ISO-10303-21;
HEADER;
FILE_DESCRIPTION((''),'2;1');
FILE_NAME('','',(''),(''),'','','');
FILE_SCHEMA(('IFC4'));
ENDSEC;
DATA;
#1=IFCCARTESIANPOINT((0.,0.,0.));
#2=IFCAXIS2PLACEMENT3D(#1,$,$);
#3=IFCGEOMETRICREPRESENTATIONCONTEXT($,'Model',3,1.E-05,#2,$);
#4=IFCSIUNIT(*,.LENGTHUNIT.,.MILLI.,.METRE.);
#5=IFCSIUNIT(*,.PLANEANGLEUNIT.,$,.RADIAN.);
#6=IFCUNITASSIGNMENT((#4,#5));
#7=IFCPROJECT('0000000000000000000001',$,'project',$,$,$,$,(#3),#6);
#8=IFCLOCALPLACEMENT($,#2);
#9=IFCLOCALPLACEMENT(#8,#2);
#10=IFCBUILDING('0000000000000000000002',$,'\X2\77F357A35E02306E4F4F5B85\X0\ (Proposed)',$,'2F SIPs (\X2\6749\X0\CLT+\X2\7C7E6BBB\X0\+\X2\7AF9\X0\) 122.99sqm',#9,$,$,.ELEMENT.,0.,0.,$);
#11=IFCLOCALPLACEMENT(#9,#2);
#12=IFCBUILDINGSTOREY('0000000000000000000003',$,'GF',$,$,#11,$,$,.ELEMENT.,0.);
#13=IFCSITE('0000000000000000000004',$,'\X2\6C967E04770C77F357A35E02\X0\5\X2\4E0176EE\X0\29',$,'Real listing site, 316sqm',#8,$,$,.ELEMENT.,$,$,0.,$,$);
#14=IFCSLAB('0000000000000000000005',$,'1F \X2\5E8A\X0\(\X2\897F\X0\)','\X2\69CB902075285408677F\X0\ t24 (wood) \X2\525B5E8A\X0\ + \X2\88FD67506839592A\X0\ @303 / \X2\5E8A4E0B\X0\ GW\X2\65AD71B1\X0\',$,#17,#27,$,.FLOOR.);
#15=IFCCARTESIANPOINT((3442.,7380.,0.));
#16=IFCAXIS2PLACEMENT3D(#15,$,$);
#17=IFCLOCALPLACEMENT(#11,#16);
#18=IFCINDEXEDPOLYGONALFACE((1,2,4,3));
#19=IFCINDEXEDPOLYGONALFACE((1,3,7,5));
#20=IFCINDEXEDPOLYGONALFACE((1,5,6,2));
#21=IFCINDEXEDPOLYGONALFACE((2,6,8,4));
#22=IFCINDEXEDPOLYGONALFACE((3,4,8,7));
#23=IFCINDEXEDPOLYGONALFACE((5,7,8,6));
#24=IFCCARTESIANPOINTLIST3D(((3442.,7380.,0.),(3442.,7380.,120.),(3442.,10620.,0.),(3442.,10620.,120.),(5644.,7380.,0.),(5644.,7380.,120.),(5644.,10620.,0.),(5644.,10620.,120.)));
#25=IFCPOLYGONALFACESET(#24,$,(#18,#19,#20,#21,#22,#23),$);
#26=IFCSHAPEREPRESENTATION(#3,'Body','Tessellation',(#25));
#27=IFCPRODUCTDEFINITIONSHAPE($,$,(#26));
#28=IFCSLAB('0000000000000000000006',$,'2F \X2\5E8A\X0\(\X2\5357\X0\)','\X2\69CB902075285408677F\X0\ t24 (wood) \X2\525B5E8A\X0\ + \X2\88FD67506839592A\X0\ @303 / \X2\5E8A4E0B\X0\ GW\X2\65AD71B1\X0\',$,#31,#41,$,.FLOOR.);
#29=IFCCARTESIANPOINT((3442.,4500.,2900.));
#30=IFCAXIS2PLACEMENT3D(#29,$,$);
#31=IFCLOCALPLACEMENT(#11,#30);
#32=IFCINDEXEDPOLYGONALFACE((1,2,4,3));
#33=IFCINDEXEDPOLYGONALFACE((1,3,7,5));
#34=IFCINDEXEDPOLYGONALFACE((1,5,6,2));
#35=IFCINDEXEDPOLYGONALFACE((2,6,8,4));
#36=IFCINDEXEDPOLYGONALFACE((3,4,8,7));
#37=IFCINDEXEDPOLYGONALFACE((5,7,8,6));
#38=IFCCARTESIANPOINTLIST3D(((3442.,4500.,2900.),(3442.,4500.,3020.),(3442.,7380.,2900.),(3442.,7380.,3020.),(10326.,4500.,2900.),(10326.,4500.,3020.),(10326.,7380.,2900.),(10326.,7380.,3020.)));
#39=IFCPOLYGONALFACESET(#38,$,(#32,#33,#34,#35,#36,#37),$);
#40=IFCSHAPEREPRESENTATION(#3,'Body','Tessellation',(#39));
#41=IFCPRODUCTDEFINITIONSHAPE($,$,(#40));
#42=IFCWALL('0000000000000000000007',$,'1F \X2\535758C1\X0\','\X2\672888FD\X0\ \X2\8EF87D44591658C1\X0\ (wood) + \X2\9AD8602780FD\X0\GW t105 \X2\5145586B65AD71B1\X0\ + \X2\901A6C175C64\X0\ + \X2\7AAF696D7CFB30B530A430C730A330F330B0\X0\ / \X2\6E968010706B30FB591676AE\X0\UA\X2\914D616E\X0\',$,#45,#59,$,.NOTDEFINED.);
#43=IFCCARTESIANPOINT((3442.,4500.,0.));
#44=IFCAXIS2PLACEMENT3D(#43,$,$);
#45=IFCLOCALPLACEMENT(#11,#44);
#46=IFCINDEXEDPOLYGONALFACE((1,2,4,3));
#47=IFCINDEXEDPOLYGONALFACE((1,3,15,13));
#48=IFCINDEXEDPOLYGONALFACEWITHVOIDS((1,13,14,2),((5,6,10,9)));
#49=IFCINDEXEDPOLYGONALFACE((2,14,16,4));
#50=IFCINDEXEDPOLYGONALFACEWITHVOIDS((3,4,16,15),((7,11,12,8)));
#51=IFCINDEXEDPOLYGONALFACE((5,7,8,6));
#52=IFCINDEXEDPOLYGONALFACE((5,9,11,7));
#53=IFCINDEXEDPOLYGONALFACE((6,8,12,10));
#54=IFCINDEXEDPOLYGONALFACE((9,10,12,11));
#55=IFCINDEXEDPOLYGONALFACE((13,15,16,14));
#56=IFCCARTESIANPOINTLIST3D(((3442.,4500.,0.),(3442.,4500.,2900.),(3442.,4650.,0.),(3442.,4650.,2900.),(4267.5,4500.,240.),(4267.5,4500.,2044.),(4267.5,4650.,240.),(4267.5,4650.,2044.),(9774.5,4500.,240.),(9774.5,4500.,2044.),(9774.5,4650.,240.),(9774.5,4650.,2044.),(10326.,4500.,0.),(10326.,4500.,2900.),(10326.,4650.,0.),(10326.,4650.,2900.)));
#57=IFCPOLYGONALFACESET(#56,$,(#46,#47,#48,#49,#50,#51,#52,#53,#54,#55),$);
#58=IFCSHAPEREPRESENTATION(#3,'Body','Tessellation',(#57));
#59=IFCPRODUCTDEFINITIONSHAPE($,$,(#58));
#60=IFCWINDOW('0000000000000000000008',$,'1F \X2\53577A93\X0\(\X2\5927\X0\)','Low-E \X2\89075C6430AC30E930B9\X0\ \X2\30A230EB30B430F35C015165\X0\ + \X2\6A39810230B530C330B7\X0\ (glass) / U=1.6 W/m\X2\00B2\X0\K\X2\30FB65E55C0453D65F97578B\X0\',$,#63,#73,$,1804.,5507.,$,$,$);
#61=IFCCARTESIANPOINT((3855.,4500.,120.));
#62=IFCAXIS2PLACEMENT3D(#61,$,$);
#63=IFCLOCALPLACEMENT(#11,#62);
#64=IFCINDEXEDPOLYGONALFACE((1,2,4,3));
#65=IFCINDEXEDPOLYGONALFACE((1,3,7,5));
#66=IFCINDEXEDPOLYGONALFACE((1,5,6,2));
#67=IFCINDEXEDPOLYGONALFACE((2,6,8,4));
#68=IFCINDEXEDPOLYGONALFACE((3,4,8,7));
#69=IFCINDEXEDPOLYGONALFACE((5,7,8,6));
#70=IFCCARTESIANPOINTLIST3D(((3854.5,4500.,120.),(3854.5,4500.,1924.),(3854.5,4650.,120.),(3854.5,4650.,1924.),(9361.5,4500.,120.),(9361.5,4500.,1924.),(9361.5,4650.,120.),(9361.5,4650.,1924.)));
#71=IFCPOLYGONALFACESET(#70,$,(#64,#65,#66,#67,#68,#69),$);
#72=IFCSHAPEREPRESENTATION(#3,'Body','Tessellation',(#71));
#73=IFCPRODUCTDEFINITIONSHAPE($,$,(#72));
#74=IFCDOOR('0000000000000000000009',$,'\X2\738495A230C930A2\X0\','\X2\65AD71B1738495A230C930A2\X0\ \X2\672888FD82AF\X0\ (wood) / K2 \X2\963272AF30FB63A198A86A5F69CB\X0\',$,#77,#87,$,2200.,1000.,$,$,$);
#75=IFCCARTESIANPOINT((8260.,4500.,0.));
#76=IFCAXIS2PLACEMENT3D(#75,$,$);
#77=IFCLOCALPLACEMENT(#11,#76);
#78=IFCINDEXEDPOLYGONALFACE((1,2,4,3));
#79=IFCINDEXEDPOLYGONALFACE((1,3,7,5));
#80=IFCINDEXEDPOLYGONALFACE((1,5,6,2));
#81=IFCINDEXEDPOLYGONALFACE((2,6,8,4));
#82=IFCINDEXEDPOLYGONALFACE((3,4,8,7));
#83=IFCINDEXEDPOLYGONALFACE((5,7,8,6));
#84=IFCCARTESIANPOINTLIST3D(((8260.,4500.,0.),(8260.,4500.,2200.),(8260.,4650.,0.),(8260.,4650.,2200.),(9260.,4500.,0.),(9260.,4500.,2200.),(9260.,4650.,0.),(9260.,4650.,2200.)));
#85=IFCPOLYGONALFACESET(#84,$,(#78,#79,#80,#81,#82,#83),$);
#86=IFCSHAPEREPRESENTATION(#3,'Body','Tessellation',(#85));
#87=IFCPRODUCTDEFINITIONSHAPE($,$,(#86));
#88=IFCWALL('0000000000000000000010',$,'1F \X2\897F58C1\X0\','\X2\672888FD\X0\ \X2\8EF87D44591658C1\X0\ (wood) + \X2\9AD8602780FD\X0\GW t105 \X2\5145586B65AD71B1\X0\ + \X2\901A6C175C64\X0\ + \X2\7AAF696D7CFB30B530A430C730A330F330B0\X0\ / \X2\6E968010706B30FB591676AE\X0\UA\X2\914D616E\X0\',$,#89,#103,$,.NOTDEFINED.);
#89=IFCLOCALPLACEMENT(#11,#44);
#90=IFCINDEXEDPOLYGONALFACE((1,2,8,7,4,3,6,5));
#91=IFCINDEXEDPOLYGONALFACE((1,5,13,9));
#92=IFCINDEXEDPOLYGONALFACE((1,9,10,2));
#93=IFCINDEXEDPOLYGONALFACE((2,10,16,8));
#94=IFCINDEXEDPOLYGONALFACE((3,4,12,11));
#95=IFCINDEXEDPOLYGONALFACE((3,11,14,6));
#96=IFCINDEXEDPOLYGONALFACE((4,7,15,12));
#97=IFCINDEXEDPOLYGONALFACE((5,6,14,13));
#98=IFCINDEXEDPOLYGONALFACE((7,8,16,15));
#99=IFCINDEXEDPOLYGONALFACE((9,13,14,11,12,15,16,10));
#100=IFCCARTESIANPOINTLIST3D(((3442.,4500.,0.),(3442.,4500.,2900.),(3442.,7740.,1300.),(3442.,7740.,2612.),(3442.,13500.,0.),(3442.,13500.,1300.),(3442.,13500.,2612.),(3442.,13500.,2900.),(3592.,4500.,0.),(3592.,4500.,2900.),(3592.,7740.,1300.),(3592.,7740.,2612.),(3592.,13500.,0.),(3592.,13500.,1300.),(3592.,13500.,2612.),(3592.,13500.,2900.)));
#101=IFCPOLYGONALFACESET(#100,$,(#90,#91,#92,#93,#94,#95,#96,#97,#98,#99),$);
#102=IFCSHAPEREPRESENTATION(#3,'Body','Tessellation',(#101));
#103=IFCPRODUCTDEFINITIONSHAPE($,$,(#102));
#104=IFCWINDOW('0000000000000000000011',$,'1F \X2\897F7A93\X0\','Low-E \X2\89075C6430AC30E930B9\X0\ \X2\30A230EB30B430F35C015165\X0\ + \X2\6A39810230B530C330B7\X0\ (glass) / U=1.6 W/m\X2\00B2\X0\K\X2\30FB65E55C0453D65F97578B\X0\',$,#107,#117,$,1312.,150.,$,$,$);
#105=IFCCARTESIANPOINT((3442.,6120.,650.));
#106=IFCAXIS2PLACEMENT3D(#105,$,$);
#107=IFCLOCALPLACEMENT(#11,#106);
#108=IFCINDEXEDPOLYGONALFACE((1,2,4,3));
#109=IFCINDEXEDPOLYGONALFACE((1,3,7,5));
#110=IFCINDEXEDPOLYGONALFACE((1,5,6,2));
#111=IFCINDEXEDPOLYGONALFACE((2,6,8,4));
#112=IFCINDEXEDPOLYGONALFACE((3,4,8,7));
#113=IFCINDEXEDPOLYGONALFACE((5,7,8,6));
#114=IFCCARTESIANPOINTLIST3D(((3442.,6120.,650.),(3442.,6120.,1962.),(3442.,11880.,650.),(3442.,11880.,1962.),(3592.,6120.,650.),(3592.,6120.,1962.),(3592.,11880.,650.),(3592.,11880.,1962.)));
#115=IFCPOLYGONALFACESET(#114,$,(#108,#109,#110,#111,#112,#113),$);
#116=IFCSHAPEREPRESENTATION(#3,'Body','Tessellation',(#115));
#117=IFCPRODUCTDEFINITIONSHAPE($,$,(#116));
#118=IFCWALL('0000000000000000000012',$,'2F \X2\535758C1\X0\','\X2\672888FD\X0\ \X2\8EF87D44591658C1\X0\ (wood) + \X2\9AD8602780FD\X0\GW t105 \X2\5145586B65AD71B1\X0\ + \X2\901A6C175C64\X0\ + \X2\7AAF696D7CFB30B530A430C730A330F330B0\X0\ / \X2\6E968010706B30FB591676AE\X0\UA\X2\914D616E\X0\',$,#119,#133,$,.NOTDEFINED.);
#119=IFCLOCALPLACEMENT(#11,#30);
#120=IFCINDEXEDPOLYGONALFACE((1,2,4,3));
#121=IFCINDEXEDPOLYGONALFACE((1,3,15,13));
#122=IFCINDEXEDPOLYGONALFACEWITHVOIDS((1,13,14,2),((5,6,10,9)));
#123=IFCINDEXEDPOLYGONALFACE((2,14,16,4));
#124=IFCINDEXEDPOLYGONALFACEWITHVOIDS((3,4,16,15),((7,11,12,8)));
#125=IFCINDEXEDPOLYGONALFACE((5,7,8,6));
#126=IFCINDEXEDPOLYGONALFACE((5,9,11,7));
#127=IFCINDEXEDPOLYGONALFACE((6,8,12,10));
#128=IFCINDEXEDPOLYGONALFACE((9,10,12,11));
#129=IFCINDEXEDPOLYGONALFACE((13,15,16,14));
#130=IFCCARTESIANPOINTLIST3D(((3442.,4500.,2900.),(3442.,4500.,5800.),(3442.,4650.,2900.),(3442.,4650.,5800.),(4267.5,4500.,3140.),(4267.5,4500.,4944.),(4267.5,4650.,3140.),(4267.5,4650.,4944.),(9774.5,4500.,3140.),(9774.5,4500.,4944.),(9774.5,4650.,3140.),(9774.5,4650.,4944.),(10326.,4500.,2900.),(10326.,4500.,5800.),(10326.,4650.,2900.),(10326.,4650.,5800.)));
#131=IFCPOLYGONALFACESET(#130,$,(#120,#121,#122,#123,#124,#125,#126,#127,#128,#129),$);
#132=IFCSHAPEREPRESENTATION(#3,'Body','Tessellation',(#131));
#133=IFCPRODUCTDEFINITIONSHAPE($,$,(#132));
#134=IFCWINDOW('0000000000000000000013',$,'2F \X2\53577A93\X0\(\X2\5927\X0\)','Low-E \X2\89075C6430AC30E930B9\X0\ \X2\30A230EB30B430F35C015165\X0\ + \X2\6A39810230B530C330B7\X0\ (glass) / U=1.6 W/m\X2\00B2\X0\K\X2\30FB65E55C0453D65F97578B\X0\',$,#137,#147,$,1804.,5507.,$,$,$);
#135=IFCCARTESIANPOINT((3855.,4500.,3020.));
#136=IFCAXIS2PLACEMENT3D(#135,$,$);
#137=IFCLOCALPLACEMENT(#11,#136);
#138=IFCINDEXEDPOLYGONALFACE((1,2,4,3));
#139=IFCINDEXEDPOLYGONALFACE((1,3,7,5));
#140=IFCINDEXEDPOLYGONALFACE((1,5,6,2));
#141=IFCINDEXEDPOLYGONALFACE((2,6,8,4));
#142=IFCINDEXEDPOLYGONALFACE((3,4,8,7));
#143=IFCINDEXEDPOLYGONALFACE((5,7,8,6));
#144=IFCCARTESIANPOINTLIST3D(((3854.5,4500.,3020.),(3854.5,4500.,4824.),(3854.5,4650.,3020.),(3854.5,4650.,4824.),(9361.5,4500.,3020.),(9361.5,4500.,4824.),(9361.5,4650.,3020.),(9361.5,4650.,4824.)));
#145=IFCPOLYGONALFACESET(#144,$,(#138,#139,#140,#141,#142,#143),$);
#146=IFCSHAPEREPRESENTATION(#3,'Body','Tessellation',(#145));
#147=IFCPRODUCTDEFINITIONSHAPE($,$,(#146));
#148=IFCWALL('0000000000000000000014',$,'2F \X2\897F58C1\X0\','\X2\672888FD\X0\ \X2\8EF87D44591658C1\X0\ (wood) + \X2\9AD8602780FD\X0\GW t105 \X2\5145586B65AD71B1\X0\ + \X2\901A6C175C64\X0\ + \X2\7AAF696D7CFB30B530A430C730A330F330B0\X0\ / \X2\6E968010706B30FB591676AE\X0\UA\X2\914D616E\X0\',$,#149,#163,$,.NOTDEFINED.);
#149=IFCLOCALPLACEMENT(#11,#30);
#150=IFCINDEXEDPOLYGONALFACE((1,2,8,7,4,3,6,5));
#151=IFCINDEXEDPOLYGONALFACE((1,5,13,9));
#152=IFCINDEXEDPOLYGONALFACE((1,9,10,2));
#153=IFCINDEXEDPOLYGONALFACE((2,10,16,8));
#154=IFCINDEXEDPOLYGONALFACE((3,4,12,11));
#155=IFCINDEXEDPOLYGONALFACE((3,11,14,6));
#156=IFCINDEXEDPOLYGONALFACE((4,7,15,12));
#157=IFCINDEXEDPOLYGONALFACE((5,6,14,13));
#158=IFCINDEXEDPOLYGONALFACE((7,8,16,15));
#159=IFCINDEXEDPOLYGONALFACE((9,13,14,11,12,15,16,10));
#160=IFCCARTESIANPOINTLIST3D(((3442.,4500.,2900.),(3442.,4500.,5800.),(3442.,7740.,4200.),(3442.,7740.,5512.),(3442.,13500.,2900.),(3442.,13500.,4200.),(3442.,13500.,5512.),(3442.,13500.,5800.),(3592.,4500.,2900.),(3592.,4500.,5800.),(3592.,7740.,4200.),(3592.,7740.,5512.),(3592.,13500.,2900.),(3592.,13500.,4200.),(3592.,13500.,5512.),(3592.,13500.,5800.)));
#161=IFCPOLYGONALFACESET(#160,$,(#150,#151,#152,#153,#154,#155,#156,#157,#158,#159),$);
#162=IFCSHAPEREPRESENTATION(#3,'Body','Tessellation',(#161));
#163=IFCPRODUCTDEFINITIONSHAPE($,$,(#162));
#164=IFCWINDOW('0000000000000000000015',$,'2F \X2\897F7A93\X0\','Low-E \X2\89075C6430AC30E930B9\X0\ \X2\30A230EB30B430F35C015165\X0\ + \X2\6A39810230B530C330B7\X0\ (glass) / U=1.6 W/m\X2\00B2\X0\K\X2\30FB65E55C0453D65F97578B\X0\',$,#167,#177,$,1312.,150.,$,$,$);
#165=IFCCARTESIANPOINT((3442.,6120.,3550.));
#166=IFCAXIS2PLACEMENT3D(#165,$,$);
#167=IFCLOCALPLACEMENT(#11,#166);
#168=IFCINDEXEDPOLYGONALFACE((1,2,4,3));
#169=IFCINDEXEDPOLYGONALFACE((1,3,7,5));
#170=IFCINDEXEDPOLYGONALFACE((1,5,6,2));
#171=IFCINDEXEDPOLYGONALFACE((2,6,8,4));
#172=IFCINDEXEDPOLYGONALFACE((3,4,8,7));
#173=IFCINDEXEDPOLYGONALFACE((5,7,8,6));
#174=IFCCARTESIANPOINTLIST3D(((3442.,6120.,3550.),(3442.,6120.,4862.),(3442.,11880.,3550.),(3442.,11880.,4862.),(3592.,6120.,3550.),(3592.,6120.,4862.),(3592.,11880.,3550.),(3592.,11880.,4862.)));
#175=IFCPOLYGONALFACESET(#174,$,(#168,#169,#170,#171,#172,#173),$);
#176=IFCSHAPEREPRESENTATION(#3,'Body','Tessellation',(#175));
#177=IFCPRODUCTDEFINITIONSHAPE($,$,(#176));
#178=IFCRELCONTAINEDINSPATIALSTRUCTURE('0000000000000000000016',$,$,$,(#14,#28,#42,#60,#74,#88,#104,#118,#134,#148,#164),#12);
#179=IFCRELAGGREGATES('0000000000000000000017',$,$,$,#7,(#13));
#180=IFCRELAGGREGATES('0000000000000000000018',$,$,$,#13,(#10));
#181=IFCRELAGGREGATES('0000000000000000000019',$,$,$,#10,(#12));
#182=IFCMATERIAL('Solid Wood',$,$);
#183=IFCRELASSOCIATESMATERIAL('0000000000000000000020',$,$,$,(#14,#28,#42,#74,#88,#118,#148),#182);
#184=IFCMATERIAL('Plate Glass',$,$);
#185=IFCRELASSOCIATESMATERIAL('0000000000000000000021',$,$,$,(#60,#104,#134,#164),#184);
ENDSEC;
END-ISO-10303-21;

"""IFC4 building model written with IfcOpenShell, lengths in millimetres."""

from ifc_helpers import new_model, si_unit, frame, frame_2d, origin, place, context, project, spatial, rectangle, extrude, material, element, fill, save


model = new_model("IFC4")

# Units and contexts
model_context = context("Model", 3, precision=1e-05, world=origin())
ifc_project = project(units=[si_unit("LENGTHUNIT", "METRE", prefix="MILLI"), si_unit("PLANEANGLEUNIT", "RADIAN")], contexts=[model_context])

# Site, building, storey
site_placement = place(None, origin())
site = spatial("IfcSite", under=ifc_project, at=site_placement, Name="沖縄県石垣市5丁目29", ObjectType="Real listing site, 316sqm", CompositionType="ELEMENT", RefElevation=0.0)
building_placement = place(site_placement, origin())
building = spatial("IfcBuilding", under=site, at=building_placement, Name="石垣市の住宅 (Proposed)", ObjectType="2F SIPs (杉CLT+籾殻+竹) 122.99sqm", CompositionType="ELEMENT", ElevationOfRefHeight=0.0, ElevationOfTerrain=0.0)
storey_placement = place(building_placement, origin())
storey = spatial("IfcBuildingStorey", under=building, at=storey_placement, Name="GF", CompositionType="ELEMENT", Elevation=0.0)

# Slabs
ifc_material_1 = material(Name="Solid Wood")
slab_1_placement = place(storey_placement, frame((3442.0, 7380.0, 0.0)))
element("IfcSlab", 1, at=slab_1_placement, inside=storey, material=ifc_material_1, Name="1F 床(西)", Description="構造用合板 t24 (wood) 剛床 + 製材根太 @303 / 床下 GW断熱", PredefinedType="FLOOR", context=model_context, shape_type="SweptSolid", body=[
    extrude(rectangle(XDim=2202.0, YDim=3240.0, at=frame_2d((1101.0, 1620.0))), frame((3442.0, 7380.0, 0.0)), (0.0, 0.0, 1.0), 120.0),
])
slab_2_placement = place(storey_placement, frame((3442.0, 4500.0, 2900.0)))
element("IfcSlab", 2, at=slab_2_placement, inside=storey, material=ifc_material_1, Name="2F 床(南)", Description="構造用合板 t24 (wood) 剛床 + 製材根太 @303 / 床下 GW断熱", PredefinedType="FLOOR", context=model_context, shape_type="SweptSolid", body=[
    extrude(rectangle(XDim=6884.0, YDim=2880.0, at=frame_2d((3442.0, 1440.0))), frame((3442.0, 4500.0, 2900.0)), (0.0, 0.0, 1.0), 120.0),
])

# Wall, openings, window, door
wall_1_placement = place(storey_placement, frame((3442.0, 4500.0, 0.0)))
wall_1 = element("IfcWall", 3, at=wall_1_placement, inside=storey, material=ifc_material_1, Name="1F 南壁", Description="木製 軸組外壁 (wood) + 高性能GW t105 充填断熱 + 通気層 + 窯業系サイディング / 準耐火・外皮UA配慮", PredefinedType="NOTDEFINED", context=model_context, shape_type="SweptSolid", body=[
    extrude(rectangle(XDim=6884.0, YDim=150.0, at=frame_2d((3442.0, 75.0))), frame((3442.0, 4500.0, 0.0)), (0.0, 0.0, 1.0), 2900.0),
])
opening_1_placement = place(storey_placement, frame((3855.0, 4500.0, 120.0)))
opening_1 = element("IfcOpeningElement", 4, at=opening_1_placement, cuts=wall_1, PredefinedType="NOTDEFINED", context=model_context, shape_type="SweptSolid", body=[
    extrude(rectangle(XDim=5507.0, YDim=150.0, at=frame_2d((2753.0, 75.0))), frame((3855.0, 4500.0, 120.0)), (0.0, 0.0, 1.0), 1804.0),
])
opening_2_placement = place(storey_placement, frame((8260.0, 4500.0, 0.0)))
opening_2 = element("IfcOpeningElement", 5, at=opening_2_placement, cuts=wall_1, PredefinedType="NOTDEFINED", context=model_context, shape_type="SweptSolid", body=[
    extrude(rectangle(XDim=1000.0, YDim=150.0, at=frame_2d((500.0, 75.0))), frame((8260.0, 4500.0, 0.0)), (0.0, 0.0, 1.0), 2200.0),
])
ifc_material_2 = material(Name="Plate Glass")
window_1_placement = place(storey_placement, frame((3855.0, 4500.0, 120.0)))
window_1 = element("IfcWindow", 6, at=window_1_placement, inside=storey, material=ifc_material_2, Name="1F 南窓(大)", Description="Low-E 複層ガラス アルゴン封入 + 樹脂サッシ (glass) / U=1.6 W/m²K・日射取得型", OverallHeight=1804.0, OverallWidth=5507.0, context=model_context, shape_type="SweptSolid", body=[
    extrude(rectangle(XDim=5507.0, YDim=150.0, at=frame_2d((2753.0, 75.0))), frame((3855.0, 4500.0, 120.0)), (0.0, 0.0, 1.0), 1804.0),
])
fill(opening_1, window_1)
door_placement = place(storey_placement, frame((8260.0, 4500.0, 0.0)))
door = element("IfcDoor", 7, at=door_placement, inside=storey, material=ifc_material_1, Name="玄関ドア", Description="断熱玄関ドア 木製芯 (wood) / K2 防犯・採風機構", OverallHeight=2200.0, OverallWidth=1000.0, context=model_context, shape_type="SweptSolid", body=[
    extrude(rectangle(XDim=1000.0, YDim=150.0, at=frame_2d((500.0, 75.0))), frame((8260.0, 4500.0, 0.0)), (0.0, 0.0, 1.0), 2200.0),
])
fill(opening_2, door)

# Walls, openings, windows
wall_2_placement = place(storey_placement, frame((3442.0, 4500.0, 0.0)))
wall_2 = element("IfcWall", 8, at=wall_2_placement, inside=storey, material=ifc_material_1, Name="1F 西壁", Description="木製 軸組外壁 (wood) + 高性能GW t105 充填断熱 + 通気層 + 窯業系サイディング / 準耐火・外皮UA配慮", PredefinedType="NOTDEFINED", context=model_context, shape_type="SweptSolid", body=[
    extrude(rectangle(XDim=150.0, YDim=9000.0, at=frame_2d((75.0, 4500.0))), frame((3442.0, 4500.0, 0.0)), (0.0, 0.0, 1.0), 2900.0),
])
opening_3_placement = place(storey_placement, frame((3442.0, 6120.0, 650.0)))
opening_3 = element("IfcOpeningElement", 9, at=opening_3_placement, cuts=wall_2, PredefinedType="NOTDEFINED", context=model_context, shape_type="SweptSolid", body=[
    extrude(rectangle(XDim=150.0, YDim=5760.0, at=frame_2d((75.0, 2880.0))), frame((3442.0, 6120.0, 650.0)), (0.0, 0.0, 1.0), 1312.0),
])
window_2_placement = place(storey_placement, frame((3442.0, 6120.0, 650.0)))
window_2 = element("IfcWindow", 10, at=window_2_placement, inside=storey, material=ifc_material_2, Name="1F 西窓", Description="Low-E 複層ガラス アルゴン封入 + 樹脂サッシ (glass) / U=1.6 W/m²K・日射取得型", OverallHeight=1312.0, OverallWidth=150.0, context=model_context, shape_type="SweptSolid", body=[
    extrude(rectangle(XDim=150.0, YDim=5760.0, at=frame_2d((75.0, 2880.0))), frame((3442.0, 6120.0, 650.0)), (0.0, 0.0, 1.0), 1312.0),
])
fill(opening_3, window_2)
wall_3_placement = place(storey_placement, frame((3442.0, 4500.0, 2900.0)))
wall_3 = element("IfcWall", 11, at=wall_3_placement, inside=storey, material=ifc_material_1, Name="2F 南壁", Description="木製 軸組外壁 (wood) + 高性能GW t105 充填断熱 + 通気層 + 窯業系サイディング / 準耐火・外皮UA配慮", PredefinedType="NOTDEFINED", context=model_context, shape_type="SweptSolid", body=[
    extrude(rectangle(XDim=6884.0, YDim=150.0, at=frame_2d((3442.0, 75.0))), frame((3442.0, 4500.0, 2900.0)), (0.0, 0.0, 1.0), 2900.0),
])
opening_4_placement = place(storey_placement, frame((3855.0, 4500.0, 3020.0)))
opening_4 = element("IfcOpeningElement", 12, at=opening_4_placement, cuts=wall_3, PredefinedType="NOTDEFINED", context=model_context, shape_type="SweptSolid", body=[
    extrude(rectangle(XDim=5507.0, YDim=150.0, at=frame_2d((2753.0, 75.0))), frame((3855.0, 4500.0, 3020.0)), (0.0, 0.0, 1.0), 1804.0),
])
window_3_placement = place(storey_placement, frame((3855.0, 4500.0, 3020.0)))
window_3 = element("IfcWindow", 13, at=window_3_placement, inside=storey, material=ifc_material_2, Name="2F 南窓(大)", Description="Low-E 複層ガラス アルゴン封入 + 樹脂サッシ (glass) / U=1.6 W/m²K・日射取得型", OverallHeight=1804.0, OverallWidth=5507.0, context=model_context, shape_type="SweptSolid", body=[
    extrude(rectangle(XDim=5507.0, YDim=150.0, at=frame_2d((2753.0, 75.0))), frame((3855.0, 4500.0, 3020.0)), (0.0, 0.0, 1.0), 1804.0),
])
fill(opening_4, window_3)
wall_4_placement = place(storey_placement, frame((3442.0, 4500.0, 2900.0)))
wall_4 = element("IfcWall", 14, at=wall_4_placement, inside=storey, material=ifc_material_1, Name="2F 西壁", Description="木製 軸組外壁 (wood) + 高性能GW t105 充填断熱 + 通気層 + 窯業系サイディング / 準耐火・外皮UA配慮", PredefinedType="NOTDEFINED", context=model_context, shape_type="SweptSolid", body=[
    extrude(rectangle(XDim=150.0, YDim=9000.0, at=frame_2d((75.0, 4500.0))), frame((3442.0, 4500.0, 2900.0)), (0.0, 0.0, 1.0), 2900.0),
])
opening_5_placement = place(storey_placement, frame((3442.0, 6120.0, 3550.0)))
opening_5 = element("IfcOpeningElement", 15, at=opening_5_placement, cuts=wall_4, PredefinedType="NOTDEFINED", context=model_context, shape_type="SweptSolid", body=[
    extrude(rectangle(XDim=150.0, YDim=5760.0, at=frame_2d((75.0, 2880.0))), frame((3442.0, 6120.0, 3550.0)), (0.0, 0.0, 1.0), 1312.0),
])
window_4_placement = place(storey_placement, frame((3442.0, 6120.0, 3550.0)))
window_4 = element("IfcWindow", 16, at=window_4_placement, inside=storey, material=ifc_material_2, Name="2F 西窓", Description="Low-E 複層ガラス アルゴン封入 + 樹脂サッシ (glass) / U=1.6 W/m²K・日射取得型", OverallHeight=1312.0, OverallWidth=150.0, context=model_context, shape_type="SweptSolid", body=[
    extrude(rectangle(XDim=150.0, YDim=5760.0, at=frame_2d((75.0, 2880.0))), frame((3442.0, 6120.0, 3550.0)), (0.0, 0.0, 1.0), 1312.0),
])
fill(opening_5, window_4)

save(model, "model.ifc")
